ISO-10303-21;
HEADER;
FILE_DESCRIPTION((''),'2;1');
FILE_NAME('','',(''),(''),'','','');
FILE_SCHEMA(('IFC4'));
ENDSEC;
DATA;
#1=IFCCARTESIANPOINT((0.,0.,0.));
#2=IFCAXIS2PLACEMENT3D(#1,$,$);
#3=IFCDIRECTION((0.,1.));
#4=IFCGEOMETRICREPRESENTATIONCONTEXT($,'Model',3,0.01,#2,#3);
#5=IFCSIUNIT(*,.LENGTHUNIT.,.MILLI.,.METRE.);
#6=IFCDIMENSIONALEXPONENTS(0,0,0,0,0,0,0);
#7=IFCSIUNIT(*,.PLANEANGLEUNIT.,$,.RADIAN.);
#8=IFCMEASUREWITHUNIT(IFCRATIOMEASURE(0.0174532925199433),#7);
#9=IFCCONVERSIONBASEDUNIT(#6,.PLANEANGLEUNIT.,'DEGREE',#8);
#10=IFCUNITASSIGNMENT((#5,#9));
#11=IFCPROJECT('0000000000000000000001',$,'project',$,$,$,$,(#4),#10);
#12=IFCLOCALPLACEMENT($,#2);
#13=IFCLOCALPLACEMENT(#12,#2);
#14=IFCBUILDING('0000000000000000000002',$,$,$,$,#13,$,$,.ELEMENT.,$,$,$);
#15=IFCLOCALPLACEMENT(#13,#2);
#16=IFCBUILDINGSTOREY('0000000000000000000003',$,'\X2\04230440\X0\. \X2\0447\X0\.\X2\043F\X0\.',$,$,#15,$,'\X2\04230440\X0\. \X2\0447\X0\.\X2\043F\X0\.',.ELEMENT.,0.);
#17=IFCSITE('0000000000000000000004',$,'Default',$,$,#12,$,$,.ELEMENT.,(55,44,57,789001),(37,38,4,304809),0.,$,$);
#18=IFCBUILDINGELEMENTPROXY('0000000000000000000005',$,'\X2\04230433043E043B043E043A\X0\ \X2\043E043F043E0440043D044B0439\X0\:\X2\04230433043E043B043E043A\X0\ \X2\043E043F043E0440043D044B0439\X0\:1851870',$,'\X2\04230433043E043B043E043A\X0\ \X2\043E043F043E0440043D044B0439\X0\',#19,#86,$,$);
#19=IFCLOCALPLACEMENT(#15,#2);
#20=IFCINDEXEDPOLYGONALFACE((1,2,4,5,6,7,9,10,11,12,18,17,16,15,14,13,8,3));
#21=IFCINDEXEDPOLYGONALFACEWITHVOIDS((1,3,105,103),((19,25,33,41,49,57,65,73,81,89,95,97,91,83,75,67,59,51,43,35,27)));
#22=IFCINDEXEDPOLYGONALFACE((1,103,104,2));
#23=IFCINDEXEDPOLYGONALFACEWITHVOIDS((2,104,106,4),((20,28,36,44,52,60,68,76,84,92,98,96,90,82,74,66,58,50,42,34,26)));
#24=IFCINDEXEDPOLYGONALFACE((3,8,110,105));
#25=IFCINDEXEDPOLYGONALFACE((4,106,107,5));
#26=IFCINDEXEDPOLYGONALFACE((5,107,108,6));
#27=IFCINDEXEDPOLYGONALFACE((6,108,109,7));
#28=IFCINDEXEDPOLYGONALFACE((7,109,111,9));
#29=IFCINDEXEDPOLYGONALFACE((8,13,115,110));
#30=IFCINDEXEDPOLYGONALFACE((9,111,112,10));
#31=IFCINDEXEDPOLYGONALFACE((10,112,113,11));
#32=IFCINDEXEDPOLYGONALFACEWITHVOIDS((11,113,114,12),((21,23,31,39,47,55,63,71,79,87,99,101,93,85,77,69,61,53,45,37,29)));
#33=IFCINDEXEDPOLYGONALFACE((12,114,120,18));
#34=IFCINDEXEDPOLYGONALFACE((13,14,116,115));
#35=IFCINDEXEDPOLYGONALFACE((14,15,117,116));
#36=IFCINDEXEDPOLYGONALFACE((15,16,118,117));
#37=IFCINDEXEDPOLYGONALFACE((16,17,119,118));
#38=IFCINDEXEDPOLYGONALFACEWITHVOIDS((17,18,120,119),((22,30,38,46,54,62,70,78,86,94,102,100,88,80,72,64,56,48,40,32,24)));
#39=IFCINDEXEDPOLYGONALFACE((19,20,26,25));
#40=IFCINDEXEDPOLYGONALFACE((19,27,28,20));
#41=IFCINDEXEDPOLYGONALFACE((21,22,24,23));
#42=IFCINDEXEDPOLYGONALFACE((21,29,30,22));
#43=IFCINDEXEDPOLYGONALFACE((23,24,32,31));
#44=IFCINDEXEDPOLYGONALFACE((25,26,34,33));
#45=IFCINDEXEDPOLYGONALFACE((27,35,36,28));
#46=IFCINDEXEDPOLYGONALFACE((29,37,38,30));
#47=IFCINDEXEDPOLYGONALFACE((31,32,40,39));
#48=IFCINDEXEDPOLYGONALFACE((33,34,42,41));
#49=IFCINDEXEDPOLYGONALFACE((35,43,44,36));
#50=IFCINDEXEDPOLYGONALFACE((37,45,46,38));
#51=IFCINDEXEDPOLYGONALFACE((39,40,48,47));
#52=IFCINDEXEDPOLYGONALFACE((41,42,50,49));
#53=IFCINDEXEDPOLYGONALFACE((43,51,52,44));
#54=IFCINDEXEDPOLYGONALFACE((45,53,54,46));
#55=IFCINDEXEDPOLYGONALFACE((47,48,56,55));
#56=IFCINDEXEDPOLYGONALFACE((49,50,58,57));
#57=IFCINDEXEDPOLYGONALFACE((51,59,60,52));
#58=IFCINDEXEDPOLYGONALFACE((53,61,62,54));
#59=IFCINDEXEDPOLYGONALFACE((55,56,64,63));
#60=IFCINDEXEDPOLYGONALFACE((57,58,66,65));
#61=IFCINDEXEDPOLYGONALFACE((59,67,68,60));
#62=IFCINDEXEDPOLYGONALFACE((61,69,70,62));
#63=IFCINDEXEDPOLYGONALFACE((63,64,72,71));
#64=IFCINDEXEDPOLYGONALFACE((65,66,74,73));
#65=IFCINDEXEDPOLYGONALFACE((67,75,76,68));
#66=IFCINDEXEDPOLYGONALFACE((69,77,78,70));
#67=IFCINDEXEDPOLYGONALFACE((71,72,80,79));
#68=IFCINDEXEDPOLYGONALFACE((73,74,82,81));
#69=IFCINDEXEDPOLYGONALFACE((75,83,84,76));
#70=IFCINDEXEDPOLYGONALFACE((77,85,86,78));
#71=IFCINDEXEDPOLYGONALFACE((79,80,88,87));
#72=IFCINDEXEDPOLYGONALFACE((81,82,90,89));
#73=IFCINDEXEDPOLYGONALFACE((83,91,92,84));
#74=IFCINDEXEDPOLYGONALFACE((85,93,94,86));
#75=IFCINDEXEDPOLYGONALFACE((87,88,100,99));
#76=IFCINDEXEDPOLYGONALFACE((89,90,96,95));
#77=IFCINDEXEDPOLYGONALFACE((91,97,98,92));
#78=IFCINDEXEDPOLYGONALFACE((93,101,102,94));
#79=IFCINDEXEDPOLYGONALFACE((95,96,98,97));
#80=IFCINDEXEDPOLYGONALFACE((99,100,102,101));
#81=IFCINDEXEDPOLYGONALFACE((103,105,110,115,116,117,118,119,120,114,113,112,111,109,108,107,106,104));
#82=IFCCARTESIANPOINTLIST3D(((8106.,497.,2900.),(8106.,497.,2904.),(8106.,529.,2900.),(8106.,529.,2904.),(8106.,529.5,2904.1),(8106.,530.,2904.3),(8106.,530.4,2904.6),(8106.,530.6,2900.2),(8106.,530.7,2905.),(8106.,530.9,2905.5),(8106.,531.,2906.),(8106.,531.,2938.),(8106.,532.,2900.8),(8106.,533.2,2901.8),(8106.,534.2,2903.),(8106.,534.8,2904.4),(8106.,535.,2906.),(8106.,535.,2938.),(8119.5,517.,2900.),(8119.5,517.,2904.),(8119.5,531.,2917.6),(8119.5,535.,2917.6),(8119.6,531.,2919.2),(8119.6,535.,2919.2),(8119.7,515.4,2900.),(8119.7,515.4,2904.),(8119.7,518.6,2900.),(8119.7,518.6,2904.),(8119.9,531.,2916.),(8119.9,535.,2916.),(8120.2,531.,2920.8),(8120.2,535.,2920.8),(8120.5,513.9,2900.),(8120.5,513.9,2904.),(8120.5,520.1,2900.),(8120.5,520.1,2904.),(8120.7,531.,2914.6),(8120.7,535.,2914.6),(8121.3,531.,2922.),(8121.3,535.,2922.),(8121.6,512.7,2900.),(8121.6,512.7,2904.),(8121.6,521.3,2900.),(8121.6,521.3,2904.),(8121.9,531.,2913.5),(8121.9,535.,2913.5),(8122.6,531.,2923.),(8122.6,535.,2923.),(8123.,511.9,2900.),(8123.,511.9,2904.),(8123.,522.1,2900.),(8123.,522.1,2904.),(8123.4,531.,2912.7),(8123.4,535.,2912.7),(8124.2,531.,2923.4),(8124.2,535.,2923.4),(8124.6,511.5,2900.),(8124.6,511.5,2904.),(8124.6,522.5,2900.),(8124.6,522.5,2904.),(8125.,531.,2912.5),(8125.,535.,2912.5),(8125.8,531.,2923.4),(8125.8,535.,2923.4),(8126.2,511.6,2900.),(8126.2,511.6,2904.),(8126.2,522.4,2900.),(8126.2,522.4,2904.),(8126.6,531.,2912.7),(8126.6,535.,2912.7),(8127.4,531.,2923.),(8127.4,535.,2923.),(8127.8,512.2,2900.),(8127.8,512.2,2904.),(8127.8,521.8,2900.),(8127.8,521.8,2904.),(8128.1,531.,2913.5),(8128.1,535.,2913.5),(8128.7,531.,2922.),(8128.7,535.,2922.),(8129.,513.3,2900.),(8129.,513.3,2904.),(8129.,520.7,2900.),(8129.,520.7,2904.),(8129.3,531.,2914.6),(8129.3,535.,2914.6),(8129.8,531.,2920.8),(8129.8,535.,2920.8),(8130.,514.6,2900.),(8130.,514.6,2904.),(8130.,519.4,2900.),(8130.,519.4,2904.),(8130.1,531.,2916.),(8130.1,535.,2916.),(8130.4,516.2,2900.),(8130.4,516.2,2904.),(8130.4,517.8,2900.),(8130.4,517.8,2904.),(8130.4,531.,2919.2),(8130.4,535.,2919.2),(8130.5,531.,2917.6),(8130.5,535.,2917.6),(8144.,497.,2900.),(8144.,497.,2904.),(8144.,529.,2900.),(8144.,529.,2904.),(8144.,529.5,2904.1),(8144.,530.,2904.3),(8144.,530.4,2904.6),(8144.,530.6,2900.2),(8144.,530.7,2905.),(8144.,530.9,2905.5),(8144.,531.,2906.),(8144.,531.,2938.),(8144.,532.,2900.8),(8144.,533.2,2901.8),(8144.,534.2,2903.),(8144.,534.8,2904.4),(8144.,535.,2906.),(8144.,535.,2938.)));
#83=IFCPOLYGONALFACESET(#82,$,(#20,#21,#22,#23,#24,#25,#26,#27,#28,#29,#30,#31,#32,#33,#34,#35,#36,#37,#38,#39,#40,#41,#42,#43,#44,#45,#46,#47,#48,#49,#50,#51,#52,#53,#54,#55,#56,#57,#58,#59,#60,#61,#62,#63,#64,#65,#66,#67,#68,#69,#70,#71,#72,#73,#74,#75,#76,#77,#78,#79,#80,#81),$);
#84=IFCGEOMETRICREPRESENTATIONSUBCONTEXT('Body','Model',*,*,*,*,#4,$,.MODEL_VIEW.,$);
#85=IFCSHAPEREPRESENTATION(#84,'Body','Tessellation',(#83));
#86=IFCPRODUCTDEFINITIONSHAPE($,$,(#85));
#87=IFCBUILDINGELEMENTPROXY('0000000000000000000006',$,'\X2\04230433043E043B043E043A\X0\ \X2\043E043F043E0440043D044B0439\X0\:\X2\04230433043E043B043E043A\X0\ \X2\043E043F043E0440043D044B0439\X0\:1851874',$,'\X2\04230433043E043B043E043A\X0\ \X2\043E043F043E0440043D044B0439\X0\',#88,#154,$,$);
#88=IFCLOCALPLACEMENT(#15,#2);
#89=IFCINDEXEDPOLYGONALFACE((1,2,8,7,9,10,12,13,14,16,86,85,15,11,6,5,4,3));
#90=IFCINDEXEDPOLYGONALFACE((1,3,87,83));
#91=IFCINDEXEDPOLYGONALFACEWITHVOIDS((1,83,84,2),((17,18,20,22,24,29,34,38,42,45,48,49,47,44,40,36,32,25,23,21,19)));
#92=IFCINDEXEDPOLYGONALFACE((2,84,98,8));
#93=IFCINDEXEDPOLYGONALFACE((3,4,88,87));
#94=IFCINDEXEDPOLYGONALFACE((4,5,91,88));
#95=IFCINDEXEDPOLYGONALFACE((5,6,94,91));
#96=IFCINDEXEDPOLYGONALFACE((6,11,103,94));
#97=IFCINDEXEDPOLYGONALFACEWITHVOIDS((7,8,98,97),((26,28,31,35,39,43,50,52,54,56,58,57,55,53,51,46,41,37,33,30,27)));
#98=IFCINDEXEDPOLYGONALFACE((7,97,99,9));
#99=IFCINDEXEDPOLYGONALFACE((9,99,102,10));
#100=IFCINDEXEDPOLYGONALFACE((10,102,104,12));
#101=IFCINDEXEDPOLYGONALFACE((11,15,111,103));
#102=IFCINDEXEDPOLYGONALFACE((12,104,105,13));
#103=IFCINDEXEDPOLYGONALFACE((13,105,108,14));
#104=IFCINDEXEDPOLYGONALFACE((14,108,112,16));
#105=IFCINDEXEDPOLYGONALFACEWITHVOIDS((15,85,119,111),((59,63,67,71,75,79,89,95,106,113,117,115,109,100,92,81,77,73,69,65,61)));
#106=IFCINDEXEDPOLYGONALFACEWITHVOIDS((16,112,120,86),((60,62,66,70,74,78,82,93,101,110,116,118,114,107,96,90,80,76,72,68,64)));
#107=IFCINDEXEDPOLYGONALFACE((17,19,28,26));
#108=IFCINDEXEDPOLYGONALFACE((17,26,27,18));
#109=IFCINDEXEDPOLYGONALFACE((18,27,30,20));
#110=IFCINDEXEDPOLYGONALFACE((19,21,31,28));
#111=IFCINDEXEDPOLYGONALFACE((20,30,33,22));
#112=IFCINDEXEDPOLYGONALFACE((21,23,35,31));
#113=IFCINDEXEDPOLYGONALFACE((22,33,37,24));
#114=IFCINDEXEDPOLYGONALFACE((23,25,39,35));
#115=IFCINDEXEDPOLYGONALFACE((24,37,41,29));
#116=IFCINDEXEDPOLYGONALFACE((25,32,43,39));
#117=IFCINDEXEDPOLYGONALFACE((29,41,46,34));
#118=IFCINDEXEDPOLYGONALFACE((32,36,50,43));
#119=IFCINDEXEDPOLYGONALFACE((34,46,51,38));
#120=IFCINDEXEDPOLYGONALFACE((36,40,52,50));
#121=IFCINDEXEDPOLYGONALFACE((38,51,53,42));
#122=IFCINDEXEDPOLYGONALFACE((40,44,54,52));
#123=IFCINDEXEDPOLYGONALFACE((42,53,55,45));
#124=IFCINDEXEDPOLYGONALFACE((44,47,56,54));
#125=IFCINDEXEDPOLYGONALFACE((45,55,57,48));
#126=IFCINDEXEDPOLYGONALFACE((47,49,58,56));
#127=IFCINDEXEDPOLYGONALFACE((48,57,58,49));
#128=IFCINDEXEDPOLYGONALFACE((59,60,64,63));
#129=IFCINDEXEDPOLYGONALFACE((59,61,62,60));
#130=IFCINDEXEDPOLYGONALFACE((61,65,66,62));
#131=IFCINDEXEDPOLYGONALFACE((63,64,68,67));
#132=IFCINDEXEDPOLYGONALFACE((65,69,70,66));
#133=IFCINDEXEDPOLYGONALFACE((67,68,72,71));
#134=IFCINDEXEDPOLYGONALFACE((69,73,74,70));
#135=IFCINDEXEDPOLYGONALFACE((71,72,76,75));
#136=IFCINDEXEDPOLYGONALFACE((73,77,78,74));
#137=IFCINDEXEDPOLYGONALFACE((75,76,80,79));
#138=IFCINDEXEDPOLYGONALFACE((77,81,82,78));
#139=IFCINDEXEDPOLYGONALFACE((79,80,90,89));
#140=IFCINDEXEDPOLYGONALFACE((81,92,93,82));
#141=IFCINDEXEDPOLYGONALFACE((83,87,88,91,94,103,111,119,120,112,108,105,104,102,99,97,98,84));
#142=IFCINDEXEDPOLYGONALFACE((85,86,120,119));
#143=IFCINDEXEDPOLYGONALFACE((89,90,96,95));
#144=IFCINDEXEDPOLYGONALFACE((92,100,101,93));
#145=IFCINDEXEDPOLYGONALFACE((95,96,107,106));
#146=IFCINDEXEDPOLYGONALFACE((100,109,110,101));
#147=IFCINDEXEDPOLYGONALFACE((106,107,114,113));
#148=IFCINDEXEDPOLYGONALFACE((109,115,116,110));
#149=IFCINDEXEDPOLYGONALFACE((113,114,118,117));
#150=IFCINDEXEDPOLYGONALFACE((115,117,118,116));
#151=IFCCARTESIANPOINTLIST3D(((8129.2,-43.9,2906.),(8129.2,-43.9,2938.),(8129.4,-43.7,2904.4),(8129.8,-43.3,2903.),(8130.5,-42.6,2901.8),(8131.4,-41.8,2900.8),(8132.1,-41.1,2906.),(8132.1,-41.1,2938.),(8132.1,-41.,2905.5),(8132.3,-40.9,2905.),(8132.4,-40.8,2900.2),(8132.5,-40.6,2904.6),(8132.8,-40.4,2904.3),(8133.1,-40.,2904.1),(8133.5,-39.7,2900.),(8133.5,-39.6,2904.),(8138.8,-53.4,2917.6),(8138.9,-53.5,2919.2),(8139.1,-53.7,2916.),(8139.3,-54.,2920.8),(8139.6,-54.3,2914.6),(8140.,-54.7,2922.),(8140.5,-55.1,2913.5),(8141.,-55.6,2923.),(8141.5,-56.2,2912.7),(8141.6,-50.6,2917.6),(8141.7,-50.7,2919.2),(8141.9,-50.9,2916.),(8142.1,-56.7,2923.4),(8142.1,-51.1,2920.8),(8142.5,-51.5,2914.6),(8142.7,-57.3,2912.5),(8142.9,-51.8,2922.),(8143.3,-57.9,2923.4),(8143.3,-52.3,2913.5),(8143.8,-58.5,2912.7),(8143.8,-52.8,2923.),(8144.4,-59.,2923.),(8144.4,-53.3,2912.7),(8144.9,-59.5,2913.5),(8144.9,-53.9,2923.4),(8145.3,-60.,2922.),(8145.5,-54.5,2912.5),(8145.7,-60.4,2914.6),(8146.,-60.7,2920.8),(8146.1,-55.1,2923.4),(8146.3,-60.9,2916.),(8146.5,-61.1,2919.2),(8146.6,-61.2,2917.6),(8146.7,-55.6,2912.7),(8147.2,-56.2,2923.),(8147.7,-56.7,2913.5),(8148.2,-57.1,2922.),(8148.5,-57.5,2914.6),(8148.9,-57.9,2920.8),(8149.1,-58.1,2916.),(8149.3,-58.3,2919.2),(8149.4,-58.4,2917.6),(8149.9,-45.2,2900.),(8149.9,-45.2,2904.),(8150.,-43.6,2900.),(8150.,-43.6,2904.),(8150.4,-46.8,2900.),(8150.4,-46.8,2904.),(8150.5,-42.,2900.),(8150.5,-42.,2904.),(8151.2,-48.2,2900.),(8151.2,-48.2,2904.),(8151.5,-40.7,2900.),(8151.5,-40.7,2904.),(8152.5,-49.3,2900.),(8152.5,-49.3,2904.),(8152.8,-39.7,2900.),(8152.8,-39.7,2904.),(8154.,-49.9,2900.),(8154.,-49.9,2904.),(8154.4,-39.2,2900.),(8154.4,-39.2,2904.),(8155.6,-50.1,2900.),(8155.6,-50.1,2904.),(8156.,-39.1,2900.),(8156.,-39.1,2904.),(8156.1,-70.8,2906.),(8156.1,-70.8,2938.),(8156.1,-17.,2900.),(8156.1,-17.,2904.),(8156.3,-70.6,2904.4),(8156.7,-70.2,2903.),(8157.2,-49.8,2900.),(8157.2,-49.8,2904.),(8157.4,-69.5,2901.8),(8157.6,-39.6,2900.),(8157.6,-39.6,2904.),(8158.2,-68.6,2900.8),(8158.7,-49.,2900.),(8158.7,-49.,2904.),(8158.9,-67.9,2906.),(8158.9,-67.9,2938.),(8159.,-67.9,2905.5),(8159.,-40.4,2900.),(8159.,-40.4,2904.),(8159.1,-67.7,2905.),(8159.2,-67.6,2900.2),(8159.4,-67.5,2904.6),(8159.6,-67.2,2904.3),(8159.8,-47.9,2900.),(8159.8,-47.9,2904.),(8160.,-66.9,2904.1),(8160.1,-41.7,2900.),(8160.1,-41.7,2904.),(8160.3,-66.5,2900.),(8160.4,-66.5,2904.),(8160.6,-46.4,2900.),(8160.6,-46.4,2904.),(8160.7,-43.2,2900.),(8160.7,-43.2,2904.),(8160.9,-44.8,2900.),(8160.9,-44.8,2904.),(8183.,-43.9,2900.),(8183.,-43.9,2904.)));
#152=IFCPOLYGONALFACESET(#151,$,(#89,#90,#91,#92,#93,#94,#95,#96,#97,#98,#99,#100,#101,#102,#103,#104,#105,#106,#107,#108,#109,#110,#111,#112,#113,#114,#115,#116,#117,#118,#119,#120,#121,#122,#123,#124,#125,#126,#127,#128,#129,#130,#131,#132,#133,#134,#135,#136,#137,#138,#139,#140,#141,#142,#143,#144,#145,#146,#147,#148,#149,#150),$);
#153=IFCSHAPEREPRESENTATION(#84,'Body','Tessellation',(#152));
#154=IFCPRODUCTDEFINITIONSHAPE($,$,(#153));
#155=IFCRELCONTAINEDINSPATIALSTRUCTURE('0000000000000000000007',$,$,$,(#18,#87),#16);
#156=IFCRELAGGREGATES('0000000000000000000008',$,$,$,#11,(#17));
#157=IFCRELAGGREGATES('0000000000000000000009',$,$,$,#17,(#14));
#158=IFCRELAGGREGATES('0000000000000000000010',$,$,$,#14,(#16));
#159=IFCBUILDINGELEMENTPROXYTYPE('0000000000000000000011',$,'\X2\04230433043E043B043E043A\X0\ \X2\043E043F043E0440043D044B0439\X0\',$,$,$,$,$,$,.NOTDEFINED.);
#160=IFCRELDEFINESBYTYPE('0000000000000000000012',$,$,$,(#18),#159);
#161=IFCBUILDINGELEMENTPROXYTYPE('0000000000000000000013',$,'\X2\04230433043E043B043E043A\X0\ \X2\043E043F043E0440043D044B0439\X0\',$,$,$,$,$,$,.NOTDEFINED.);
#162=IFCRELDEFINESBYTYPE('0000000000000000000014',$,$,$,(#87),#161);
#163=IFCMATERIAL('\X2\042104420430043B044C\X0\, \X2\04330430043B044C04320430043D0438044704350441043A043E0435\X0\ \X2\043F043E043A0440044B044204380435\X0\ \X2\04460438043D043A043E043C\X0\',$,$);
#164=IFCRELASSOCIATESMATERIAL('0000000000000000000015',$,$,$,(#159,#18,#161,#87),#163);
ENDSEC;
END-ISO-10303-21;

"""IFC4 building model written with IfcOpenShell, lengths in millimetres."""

from ifc_helpers import new_model, entity, si_unit, converted_unit, direction, frame, frame_2d, origin, place, context, subcontext, project, spatial, polyline, circle_curve, parameter, trimmed, segment, composite_curve, circle, outline, extrude, source, transform, mapped, material, type_object, type_shapes, element, save


model = new_model("IFC4")

# Units and contexts
model_context = context("Model", 3, precision=0.01, world=origin(), true_north=direction((0.0, 1.0)))
body_context = subcontext(model_context, "Body", "Model", "MODEL_VIEW")
ifc_project = project(units=[si_unit("LENGTHUNIT", "METRE", prefix="MILLI"), converted_unit("PLANEANGLEUNIT", "DEGREE", entity("IfcRatioMeasure", 0.0174532925199433), si_unit("PLANEANGLEUNIT", "RADIAN"), dimensions=[0, 0, 0, 0, 0, 0, 0])], contexts=[model_context])

# Site, building, storey
site_placement = place(None, origin())
site = spatial("IfcSite", under=ifc_project, at=site_placement, Name="Default", CompositionType="ELEMENT", RefLatitude=(55, 44, 57, 789001), RefLongitude=(37, 38, 4, 304809), RefElevation=0.0)
building_placement = place(site_placement, origin())
building = spatial("IfcBuilding", under=site, at=building_placement, CompositionType="ELEMENT")
storey_placement = place(building_placement, origin())
storey = spatial("IfcBuildingStorey", under=building, at=storey_placement, Name="Ур. ч.п.", LongName="Ур. ч.п.", CompositionType="ELEMENT", Elevation=0.0)

# Building element proxies, openings
ifc_material = material(Name="Сталь, гальваническое покрытие цинком")
building_element_proxy_type_1 = type_object("IfcBuildingElementProxyType", Name="Уголок опорный", material=ifc_material)
shared_shape_1 = source(origin(), body_context, "Body", "SweptSolid", [
    extrude(outline(composite_curve([segment(polyline([(-6.0, -12.0), (26.0, -12.0)]), True, "CONTINUOUS"), segment(polyline([(26.0, -12.0), (26.0, -8.0)]), True, "CONTINUOUS"), segment(polyline([(26.0, -8.0), (-6.0, -8.0)]), True, "CONTINUOUS"), segment(trimmed(circle_curve(frame_2d((-6.0, -6.0), x_axis=(0.0, -1.0)), 2.0), [parameter(270.0)], [parameter(0.0)], True, "PARAMETER"), False, "CONTINUOUS"), segment(polyline([(-8.0, -6.0), (-8.0, 26.0)]), True, "CONTINUOUS"), segment(polyline([(-8.0, 26.0), (-12.0, 26.0)]), True, "CONTINUOUS"), segment(polyline([(-12.0, 26.0), (-12.0, -6.0)]), True, "CONTINUOUS"), segment(trimmed(circle_curve(frame_2d((-6.0, -6.0), x_axis=(0.0, -1.0)), 6.0), [parameter(270.0)], [parameter(360.0)], True, "PARAMETER"), True, "CONTINUOUS")], self_intersect=False)), frame((12.0, -19.0, 12.0), z_axis=(0.0, 1.0, 0.0), x_axis=(0.0, 0.0, 1.0)), (0.0, 0.0, 1.0), 38.0),
])
type_shapes(building_element_proxy_type_1, [shared_shape_1])
proxy_1_placement = place(storey_placement, frame((8125.0, 535.0, 2900.0), z_axis=(0.0, 0.0, 1.0), x_axis=(0.0, -1.0, 0.0)))
proxy_1 = element("IfcBuildingElementProxy", 1, at=proxy_1_placement, inside=storey, type_object=building_element_proxy_type_1, material=ifc_material, Name="Уголок опорный:Уголок опорный:1851870", ObjectType="Уголок опорный", context=body_context, shape_type="MappedRepresentation", body=[
    mapped(shared_shape_1, transform((0.0, 0.0, 0.0), scale=1.0)),
])
opening_1_placement = place(storey_placement, frame((8125.0, 535.0, 2900.0), z_axis=(0.0, 0.0, 1.0), x_axis=(-1.0, 0.0, 0.0)))
element("IfcOpeningElement", 2, at=opening_1_placement, cuts=proxy_1, ObjectType="Opening", PredefinedType="OPENING", context=body_context, shape_type="SweptSolid", body=[
    extrude(circle(Radius=5.5, at=frame_2d((0.0, 0.0), x_axis=(1.0, 0.0))), frame((0.0, 0.0, 18.0), z_axis=(0.0, 1.0, 0.0), x_axis=(0.0, 0.0, -1.0)), (0.0, 0.0, 1.0), 4.0),
])
opening_2_placement = place(storey_placement, frame((8125.0, 535.0, 2900.0), z_axis=(0.0, 0.0, 1.0), x_axis=(-1.0, 0.0, 0.0)))
element("IfcOpeningElement", 3, at=opening_2_placement, cuts=proxy_1, ObjectType="Opening", PredefinedType="OPENING", context=body_context, shape_type="SweptSolid", body=[
    extrude(circle(Radius=5.5, at=frame_2d((0.0, 0.0), x_axis=(1.0, 0.0))), frame((0.0, 18.0, 0.0)), (0.0, 0.0, 1.0), 4.0),
])
building_element_proxy_type_2 = type_object("IfcBuildingElementProxyType", Name="Уголок опорный", material=ifc_material)
shared_shape_2 = source(origin(), body_context, "Body", "SweptSolid", [
    extrude(outline(composite_curve([segment(polyline([(-6.0, -12.0), (26.0, -12.0)]), True, "CONTINUOUS"), segment(polyline([(26.0, -12.0), (26.0, -8.0)]), True, "CONTINUOUS"), segment(polyline([(26.0, -8.0), (-6.0, -8.0)]), True, "CONTINUOUS"), segment(trimmed(circle_curve(frame_2d((-6.0, -6.0), x_axis=(0.0, -1.0)), 2.0), [parameter(270.0)], [parameter(0.0)], True, "PARAMETER"), False, "CONTINUOUS"), segment(polyline([(-8.0, -6.0), (-8.0, 26.0)]), True, "CONTINUOUS"), segment(polyline([(-8.0, 26.0), (-12.0, 26.0)]), True, "CONTINUOUS"), segment(polyline([(-12.0, 26.0), (-12.0, -6.0)]), True, "CONTINUOUS"), segment(trimmed(circle_curve(frame_2d((-6.0, -6.0), x_axis=(0.0, -1.0)), 6.0), [parameter(270.0)], [parameter(360.0)], True, "PARAMETER"), True, "CONTINUOUS")], self_intersect=False)), frame((12.0, -19.0, 12.0), z_axis=(0.0, 1.0, 0.0), x_axis=(0.0, 0.0, 1.0)), (0.0, 0.0, 1.0), 38.0),
])
type_shapes(building_element_proxy_type_2, [shared_shape_2])
proxy_2_placement = place(storey_placement, frame((8142.7, -57.3, 2900.0), z_axis=(0.0, 0.0, 1.0), x_axis=(0.707107, 0.707107, 0.0)))
proxy_2 = element("IfcBuildingElementProxy", 4, at=proxy_2_placement, inside=storey, type_object=building_element_proxy_type_2, material=ifc_material, Name="Уголок опорный:Уголок опорный:1851874", ObjectType="Уголок опорный", context=body_context, shape_type="MappedRepresentation", body=[
    mapped(shared_shape_2, transform((0.0, 0.0, 0.0), scale=1.0)),
])
opening_3_placement = place(storey_placement, frame((8142.7, -57.3, 2900.0), z_axis=(0.0, 0.0, 1.0), x_axis=(0.0, 1.0, 0.0)))
element("IfcOpeningElement", 5, at=opening_3_placement, cuts=proxy_2, ObjectType="Opening", PredefinedType="OPENING", context=body_context, shape_type="SweptSolid", body=[
    extrude(circle(Radius=5.5, at=frame_2d((0.0, 0.0), x_axis=(1.0, 0.0))), frame((2.8, -2.8, 18.0), z_axis=(-0.707107, 0.707107, 0.0), x_axis=(0.0, 0.0, -1.0)), (0.0, 0.0, 1.0), 4.0),
])
opening_4_placement = place(storey_placement, frame((8142.7, -57.3, 2900.0), z_axis=(0.0, 0.0, 1.0), x_axis=(0.0, 1.0, 0.0)))
element("IfcOpeningElement", 6, at=opening_4_placement, cuts=proxy_2, ObjectType="Opening", PredefinedType="OPENING", context=body_context, shape_type="SweptSolid", body=[
    extrude(circle(Radius=5.5, at=frame_2d((0.0, 0.0), x_axis=(1.0, 0.0))), frame((12.7, -12.7, 0.0), z_axis=(0.0, 0.0, 1.0), x_axis=(0.707107, 0.707107, 0.0)), (0.0, 0.0, 1.0), 4.0),
])

save(model, "model.ifc")
